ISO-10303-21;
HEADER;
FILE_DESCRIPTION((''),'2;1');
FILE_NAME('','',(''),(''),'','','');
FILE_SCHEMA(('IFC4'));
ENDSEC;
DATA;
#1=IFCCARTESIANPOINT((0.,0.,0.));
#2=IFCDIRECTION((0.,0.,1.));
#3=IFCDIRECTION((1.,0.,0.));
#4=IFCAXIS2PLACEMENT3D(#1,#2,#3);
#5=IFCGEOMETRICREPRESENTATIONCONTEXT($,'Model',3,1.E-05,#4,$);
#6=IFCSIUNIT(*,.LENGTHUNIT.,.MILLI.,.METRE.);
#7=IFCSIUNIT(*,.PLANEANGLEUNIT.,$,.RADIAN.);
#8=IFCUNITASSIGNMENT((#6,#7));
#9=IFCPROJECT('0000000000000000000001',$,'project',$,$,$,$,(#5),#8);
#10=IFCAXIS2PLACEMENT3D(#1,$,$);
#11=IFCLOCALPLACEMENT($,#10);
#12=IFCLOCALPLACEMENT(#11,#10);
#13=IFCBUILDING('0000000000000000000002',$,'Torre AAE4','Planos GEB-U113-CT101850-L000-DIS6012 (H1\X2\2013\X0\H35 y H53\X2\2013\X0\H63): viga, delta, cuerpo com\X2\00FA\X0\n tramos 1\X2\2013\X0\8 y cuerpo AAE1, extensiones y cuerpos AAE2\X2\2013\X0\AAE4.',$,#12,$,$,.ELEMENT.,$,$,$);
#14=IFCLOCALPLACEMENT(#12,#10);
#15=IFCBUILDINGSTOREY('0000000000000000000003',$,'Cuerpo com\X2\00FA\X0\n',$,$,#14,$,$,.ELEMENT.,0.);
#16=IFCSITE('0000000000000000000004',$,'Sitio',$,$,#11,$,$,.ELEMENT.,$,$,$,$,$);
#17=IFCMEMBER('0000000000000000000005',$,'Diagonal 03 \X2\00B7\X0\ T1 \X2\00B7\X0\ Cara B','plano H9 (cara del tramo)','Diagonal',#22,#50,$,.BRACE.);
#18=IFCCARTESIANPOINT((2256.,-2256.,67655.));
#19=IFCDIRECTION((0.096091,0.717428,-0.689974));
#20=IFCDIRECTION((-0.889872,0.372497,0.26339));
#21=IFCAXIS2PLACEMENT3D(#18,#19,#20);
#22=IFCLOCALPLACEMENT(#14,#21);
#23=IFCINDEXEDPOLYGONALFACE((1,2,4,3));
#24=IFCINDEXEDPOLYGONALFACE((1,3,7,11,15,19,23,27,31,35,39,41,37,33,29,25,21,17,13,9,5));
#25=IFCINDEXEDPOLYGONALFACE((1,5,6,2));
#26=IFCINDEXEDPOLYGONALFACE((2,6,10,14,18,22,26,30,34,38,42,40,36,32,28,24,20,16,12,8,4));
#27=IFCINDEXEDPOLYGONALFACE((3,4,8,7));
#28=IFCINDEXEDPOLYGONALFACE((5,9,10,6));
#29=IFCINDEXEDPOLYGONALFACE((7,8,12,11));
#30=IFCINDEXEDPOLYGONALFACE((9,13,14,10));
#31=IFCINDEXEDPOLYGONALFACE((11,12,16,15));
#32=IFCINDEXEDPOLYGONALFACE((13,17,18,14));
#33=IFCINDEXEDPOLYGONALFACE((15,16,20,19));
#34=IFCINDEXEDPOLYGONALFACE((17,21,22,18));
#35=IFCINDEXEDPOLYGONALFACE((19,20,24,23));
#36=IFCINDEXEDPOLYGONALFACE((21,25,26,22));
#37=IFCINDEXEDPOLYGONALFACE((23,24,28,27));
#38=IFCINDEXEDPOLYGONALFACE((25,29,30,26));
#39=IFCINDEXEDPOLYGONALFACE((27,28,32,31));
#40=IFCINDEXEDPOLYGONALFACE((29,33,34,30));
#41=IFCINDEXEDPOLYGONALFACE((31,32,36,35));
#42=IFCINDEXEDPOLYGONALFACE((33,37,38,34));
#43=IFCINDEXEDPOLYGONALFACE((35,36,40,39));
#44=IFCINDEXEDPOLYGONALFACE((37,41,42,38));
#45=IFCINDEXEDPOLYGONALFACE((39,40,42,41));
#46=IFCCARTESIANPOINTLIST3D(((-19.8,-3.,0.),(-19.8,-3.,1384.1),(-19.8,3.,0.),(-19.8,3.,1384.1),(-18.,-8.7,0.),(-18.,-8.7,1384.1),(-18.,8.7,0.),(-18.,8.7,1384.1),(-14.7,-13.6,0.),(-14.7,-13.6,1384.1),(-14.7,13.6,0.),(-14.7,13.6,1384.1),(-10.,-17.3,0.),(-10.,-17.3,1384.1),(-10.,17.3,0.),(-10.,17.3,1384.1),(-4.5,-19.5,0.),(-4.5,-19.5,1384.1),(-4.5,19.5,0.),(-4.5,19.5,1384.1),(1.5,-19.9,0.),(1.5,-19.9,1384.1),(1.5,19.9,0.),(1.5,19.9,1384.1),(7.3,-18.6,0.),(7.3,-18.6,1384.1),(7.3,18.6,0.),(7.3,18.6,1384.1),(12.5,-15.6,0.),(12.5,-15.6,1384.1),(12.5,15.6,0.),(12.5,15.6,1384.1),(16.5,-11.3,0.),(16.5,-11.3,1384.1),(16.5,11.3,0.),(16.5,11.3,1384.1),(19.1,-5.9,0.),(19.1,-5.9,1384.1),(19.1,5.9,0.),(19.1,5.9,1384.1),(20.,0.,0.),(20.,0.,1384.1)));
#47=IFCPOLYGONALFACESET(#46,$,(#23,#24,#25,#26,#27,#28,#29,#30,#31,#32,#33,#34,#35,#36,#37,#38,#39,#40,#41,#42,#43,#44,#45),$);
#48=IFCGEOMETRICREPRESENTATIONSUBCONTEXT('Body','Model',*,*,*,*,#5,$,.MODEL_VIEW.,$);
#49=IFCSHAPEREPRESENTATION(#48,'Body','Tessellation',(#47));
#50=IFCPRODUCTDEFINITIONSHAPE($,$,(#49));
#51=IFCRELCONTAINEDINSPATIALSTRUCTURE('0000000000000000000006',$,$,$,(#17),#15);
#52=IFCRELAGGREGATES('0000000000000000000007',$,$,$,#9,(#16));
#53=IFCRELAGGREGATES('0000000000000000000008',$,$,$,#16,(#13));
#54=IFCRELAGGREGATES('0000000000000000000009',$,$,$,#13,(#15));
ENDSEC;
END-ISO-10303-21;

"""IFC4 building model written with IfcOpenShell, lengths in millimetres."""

from ifc_helpers import new_model, si_unit, frame, origin, origin_with_axes, place, context, subcontext, project, spatial, circle, extrude, element, save


model = new_model("IFC4")

# Units and contexts
model_context = context("Model", 3, precision=1e-05, world=origin_with_axes())
body_context = subcontext(model_context, "Body", "Model", "MODEL_VIEW")
ifc_project = project(units=[si_unit("LENGTHUNIT", "METRE", prefix="MILLI"), si_unit("PLANEANGLEUNIT", "RADIAN")], contexts=[model_context])

# Site, building, storey
site_placement = place(None, origin())
site = spatial("IfcSite", under=ifc_project, at=site_placement, Name="Sitio", CompositionType="ELEMENT")
building_placement = place(site_placement, origin())
building = spatial("IfcBuilding", under=site, at=building_placement, Name="Torre AAE4", Description="Planos GEB-U113-CT101850-L000-DIS6012 (H1–H35 y H53–H63): viga, delta, cuerpo común tramos 1–8 y cuerpo AAE1, extensiones y cuerpos AAE2–AAE4.", CompositionType="ELEMENT")
storey_placement = place(building_placement, origin())
storey = spatial("IfcBuildingStorey", under=building, at=storey_placement, Name="Cuerpo común", CompositionType="ELEMENT", Elevation=0.0)

# Member
member_1_placement = place(storey_placement, frame((2256.0, -2256.0, 67655.0), z_axis=(0.096091, 0.717428, -0.689974), x_axis=(-0.889872, 0.372497, 0.26339)))
element("IfcMember", 1, at=member_1_placement, inside=storey, Name="Diagonal 03 · T1 · Cara B", Description="plano H9 (cara del tramo)", ObjectType="Diagonal", PredefinedType="BRACE", context=body_context, shape_type="SweptSolid", body=[
    extrude(circle(Radius=20.0), None, (0.0, 0.0, 1.0), 1384.1),
])

save(model, "model.ifc")
